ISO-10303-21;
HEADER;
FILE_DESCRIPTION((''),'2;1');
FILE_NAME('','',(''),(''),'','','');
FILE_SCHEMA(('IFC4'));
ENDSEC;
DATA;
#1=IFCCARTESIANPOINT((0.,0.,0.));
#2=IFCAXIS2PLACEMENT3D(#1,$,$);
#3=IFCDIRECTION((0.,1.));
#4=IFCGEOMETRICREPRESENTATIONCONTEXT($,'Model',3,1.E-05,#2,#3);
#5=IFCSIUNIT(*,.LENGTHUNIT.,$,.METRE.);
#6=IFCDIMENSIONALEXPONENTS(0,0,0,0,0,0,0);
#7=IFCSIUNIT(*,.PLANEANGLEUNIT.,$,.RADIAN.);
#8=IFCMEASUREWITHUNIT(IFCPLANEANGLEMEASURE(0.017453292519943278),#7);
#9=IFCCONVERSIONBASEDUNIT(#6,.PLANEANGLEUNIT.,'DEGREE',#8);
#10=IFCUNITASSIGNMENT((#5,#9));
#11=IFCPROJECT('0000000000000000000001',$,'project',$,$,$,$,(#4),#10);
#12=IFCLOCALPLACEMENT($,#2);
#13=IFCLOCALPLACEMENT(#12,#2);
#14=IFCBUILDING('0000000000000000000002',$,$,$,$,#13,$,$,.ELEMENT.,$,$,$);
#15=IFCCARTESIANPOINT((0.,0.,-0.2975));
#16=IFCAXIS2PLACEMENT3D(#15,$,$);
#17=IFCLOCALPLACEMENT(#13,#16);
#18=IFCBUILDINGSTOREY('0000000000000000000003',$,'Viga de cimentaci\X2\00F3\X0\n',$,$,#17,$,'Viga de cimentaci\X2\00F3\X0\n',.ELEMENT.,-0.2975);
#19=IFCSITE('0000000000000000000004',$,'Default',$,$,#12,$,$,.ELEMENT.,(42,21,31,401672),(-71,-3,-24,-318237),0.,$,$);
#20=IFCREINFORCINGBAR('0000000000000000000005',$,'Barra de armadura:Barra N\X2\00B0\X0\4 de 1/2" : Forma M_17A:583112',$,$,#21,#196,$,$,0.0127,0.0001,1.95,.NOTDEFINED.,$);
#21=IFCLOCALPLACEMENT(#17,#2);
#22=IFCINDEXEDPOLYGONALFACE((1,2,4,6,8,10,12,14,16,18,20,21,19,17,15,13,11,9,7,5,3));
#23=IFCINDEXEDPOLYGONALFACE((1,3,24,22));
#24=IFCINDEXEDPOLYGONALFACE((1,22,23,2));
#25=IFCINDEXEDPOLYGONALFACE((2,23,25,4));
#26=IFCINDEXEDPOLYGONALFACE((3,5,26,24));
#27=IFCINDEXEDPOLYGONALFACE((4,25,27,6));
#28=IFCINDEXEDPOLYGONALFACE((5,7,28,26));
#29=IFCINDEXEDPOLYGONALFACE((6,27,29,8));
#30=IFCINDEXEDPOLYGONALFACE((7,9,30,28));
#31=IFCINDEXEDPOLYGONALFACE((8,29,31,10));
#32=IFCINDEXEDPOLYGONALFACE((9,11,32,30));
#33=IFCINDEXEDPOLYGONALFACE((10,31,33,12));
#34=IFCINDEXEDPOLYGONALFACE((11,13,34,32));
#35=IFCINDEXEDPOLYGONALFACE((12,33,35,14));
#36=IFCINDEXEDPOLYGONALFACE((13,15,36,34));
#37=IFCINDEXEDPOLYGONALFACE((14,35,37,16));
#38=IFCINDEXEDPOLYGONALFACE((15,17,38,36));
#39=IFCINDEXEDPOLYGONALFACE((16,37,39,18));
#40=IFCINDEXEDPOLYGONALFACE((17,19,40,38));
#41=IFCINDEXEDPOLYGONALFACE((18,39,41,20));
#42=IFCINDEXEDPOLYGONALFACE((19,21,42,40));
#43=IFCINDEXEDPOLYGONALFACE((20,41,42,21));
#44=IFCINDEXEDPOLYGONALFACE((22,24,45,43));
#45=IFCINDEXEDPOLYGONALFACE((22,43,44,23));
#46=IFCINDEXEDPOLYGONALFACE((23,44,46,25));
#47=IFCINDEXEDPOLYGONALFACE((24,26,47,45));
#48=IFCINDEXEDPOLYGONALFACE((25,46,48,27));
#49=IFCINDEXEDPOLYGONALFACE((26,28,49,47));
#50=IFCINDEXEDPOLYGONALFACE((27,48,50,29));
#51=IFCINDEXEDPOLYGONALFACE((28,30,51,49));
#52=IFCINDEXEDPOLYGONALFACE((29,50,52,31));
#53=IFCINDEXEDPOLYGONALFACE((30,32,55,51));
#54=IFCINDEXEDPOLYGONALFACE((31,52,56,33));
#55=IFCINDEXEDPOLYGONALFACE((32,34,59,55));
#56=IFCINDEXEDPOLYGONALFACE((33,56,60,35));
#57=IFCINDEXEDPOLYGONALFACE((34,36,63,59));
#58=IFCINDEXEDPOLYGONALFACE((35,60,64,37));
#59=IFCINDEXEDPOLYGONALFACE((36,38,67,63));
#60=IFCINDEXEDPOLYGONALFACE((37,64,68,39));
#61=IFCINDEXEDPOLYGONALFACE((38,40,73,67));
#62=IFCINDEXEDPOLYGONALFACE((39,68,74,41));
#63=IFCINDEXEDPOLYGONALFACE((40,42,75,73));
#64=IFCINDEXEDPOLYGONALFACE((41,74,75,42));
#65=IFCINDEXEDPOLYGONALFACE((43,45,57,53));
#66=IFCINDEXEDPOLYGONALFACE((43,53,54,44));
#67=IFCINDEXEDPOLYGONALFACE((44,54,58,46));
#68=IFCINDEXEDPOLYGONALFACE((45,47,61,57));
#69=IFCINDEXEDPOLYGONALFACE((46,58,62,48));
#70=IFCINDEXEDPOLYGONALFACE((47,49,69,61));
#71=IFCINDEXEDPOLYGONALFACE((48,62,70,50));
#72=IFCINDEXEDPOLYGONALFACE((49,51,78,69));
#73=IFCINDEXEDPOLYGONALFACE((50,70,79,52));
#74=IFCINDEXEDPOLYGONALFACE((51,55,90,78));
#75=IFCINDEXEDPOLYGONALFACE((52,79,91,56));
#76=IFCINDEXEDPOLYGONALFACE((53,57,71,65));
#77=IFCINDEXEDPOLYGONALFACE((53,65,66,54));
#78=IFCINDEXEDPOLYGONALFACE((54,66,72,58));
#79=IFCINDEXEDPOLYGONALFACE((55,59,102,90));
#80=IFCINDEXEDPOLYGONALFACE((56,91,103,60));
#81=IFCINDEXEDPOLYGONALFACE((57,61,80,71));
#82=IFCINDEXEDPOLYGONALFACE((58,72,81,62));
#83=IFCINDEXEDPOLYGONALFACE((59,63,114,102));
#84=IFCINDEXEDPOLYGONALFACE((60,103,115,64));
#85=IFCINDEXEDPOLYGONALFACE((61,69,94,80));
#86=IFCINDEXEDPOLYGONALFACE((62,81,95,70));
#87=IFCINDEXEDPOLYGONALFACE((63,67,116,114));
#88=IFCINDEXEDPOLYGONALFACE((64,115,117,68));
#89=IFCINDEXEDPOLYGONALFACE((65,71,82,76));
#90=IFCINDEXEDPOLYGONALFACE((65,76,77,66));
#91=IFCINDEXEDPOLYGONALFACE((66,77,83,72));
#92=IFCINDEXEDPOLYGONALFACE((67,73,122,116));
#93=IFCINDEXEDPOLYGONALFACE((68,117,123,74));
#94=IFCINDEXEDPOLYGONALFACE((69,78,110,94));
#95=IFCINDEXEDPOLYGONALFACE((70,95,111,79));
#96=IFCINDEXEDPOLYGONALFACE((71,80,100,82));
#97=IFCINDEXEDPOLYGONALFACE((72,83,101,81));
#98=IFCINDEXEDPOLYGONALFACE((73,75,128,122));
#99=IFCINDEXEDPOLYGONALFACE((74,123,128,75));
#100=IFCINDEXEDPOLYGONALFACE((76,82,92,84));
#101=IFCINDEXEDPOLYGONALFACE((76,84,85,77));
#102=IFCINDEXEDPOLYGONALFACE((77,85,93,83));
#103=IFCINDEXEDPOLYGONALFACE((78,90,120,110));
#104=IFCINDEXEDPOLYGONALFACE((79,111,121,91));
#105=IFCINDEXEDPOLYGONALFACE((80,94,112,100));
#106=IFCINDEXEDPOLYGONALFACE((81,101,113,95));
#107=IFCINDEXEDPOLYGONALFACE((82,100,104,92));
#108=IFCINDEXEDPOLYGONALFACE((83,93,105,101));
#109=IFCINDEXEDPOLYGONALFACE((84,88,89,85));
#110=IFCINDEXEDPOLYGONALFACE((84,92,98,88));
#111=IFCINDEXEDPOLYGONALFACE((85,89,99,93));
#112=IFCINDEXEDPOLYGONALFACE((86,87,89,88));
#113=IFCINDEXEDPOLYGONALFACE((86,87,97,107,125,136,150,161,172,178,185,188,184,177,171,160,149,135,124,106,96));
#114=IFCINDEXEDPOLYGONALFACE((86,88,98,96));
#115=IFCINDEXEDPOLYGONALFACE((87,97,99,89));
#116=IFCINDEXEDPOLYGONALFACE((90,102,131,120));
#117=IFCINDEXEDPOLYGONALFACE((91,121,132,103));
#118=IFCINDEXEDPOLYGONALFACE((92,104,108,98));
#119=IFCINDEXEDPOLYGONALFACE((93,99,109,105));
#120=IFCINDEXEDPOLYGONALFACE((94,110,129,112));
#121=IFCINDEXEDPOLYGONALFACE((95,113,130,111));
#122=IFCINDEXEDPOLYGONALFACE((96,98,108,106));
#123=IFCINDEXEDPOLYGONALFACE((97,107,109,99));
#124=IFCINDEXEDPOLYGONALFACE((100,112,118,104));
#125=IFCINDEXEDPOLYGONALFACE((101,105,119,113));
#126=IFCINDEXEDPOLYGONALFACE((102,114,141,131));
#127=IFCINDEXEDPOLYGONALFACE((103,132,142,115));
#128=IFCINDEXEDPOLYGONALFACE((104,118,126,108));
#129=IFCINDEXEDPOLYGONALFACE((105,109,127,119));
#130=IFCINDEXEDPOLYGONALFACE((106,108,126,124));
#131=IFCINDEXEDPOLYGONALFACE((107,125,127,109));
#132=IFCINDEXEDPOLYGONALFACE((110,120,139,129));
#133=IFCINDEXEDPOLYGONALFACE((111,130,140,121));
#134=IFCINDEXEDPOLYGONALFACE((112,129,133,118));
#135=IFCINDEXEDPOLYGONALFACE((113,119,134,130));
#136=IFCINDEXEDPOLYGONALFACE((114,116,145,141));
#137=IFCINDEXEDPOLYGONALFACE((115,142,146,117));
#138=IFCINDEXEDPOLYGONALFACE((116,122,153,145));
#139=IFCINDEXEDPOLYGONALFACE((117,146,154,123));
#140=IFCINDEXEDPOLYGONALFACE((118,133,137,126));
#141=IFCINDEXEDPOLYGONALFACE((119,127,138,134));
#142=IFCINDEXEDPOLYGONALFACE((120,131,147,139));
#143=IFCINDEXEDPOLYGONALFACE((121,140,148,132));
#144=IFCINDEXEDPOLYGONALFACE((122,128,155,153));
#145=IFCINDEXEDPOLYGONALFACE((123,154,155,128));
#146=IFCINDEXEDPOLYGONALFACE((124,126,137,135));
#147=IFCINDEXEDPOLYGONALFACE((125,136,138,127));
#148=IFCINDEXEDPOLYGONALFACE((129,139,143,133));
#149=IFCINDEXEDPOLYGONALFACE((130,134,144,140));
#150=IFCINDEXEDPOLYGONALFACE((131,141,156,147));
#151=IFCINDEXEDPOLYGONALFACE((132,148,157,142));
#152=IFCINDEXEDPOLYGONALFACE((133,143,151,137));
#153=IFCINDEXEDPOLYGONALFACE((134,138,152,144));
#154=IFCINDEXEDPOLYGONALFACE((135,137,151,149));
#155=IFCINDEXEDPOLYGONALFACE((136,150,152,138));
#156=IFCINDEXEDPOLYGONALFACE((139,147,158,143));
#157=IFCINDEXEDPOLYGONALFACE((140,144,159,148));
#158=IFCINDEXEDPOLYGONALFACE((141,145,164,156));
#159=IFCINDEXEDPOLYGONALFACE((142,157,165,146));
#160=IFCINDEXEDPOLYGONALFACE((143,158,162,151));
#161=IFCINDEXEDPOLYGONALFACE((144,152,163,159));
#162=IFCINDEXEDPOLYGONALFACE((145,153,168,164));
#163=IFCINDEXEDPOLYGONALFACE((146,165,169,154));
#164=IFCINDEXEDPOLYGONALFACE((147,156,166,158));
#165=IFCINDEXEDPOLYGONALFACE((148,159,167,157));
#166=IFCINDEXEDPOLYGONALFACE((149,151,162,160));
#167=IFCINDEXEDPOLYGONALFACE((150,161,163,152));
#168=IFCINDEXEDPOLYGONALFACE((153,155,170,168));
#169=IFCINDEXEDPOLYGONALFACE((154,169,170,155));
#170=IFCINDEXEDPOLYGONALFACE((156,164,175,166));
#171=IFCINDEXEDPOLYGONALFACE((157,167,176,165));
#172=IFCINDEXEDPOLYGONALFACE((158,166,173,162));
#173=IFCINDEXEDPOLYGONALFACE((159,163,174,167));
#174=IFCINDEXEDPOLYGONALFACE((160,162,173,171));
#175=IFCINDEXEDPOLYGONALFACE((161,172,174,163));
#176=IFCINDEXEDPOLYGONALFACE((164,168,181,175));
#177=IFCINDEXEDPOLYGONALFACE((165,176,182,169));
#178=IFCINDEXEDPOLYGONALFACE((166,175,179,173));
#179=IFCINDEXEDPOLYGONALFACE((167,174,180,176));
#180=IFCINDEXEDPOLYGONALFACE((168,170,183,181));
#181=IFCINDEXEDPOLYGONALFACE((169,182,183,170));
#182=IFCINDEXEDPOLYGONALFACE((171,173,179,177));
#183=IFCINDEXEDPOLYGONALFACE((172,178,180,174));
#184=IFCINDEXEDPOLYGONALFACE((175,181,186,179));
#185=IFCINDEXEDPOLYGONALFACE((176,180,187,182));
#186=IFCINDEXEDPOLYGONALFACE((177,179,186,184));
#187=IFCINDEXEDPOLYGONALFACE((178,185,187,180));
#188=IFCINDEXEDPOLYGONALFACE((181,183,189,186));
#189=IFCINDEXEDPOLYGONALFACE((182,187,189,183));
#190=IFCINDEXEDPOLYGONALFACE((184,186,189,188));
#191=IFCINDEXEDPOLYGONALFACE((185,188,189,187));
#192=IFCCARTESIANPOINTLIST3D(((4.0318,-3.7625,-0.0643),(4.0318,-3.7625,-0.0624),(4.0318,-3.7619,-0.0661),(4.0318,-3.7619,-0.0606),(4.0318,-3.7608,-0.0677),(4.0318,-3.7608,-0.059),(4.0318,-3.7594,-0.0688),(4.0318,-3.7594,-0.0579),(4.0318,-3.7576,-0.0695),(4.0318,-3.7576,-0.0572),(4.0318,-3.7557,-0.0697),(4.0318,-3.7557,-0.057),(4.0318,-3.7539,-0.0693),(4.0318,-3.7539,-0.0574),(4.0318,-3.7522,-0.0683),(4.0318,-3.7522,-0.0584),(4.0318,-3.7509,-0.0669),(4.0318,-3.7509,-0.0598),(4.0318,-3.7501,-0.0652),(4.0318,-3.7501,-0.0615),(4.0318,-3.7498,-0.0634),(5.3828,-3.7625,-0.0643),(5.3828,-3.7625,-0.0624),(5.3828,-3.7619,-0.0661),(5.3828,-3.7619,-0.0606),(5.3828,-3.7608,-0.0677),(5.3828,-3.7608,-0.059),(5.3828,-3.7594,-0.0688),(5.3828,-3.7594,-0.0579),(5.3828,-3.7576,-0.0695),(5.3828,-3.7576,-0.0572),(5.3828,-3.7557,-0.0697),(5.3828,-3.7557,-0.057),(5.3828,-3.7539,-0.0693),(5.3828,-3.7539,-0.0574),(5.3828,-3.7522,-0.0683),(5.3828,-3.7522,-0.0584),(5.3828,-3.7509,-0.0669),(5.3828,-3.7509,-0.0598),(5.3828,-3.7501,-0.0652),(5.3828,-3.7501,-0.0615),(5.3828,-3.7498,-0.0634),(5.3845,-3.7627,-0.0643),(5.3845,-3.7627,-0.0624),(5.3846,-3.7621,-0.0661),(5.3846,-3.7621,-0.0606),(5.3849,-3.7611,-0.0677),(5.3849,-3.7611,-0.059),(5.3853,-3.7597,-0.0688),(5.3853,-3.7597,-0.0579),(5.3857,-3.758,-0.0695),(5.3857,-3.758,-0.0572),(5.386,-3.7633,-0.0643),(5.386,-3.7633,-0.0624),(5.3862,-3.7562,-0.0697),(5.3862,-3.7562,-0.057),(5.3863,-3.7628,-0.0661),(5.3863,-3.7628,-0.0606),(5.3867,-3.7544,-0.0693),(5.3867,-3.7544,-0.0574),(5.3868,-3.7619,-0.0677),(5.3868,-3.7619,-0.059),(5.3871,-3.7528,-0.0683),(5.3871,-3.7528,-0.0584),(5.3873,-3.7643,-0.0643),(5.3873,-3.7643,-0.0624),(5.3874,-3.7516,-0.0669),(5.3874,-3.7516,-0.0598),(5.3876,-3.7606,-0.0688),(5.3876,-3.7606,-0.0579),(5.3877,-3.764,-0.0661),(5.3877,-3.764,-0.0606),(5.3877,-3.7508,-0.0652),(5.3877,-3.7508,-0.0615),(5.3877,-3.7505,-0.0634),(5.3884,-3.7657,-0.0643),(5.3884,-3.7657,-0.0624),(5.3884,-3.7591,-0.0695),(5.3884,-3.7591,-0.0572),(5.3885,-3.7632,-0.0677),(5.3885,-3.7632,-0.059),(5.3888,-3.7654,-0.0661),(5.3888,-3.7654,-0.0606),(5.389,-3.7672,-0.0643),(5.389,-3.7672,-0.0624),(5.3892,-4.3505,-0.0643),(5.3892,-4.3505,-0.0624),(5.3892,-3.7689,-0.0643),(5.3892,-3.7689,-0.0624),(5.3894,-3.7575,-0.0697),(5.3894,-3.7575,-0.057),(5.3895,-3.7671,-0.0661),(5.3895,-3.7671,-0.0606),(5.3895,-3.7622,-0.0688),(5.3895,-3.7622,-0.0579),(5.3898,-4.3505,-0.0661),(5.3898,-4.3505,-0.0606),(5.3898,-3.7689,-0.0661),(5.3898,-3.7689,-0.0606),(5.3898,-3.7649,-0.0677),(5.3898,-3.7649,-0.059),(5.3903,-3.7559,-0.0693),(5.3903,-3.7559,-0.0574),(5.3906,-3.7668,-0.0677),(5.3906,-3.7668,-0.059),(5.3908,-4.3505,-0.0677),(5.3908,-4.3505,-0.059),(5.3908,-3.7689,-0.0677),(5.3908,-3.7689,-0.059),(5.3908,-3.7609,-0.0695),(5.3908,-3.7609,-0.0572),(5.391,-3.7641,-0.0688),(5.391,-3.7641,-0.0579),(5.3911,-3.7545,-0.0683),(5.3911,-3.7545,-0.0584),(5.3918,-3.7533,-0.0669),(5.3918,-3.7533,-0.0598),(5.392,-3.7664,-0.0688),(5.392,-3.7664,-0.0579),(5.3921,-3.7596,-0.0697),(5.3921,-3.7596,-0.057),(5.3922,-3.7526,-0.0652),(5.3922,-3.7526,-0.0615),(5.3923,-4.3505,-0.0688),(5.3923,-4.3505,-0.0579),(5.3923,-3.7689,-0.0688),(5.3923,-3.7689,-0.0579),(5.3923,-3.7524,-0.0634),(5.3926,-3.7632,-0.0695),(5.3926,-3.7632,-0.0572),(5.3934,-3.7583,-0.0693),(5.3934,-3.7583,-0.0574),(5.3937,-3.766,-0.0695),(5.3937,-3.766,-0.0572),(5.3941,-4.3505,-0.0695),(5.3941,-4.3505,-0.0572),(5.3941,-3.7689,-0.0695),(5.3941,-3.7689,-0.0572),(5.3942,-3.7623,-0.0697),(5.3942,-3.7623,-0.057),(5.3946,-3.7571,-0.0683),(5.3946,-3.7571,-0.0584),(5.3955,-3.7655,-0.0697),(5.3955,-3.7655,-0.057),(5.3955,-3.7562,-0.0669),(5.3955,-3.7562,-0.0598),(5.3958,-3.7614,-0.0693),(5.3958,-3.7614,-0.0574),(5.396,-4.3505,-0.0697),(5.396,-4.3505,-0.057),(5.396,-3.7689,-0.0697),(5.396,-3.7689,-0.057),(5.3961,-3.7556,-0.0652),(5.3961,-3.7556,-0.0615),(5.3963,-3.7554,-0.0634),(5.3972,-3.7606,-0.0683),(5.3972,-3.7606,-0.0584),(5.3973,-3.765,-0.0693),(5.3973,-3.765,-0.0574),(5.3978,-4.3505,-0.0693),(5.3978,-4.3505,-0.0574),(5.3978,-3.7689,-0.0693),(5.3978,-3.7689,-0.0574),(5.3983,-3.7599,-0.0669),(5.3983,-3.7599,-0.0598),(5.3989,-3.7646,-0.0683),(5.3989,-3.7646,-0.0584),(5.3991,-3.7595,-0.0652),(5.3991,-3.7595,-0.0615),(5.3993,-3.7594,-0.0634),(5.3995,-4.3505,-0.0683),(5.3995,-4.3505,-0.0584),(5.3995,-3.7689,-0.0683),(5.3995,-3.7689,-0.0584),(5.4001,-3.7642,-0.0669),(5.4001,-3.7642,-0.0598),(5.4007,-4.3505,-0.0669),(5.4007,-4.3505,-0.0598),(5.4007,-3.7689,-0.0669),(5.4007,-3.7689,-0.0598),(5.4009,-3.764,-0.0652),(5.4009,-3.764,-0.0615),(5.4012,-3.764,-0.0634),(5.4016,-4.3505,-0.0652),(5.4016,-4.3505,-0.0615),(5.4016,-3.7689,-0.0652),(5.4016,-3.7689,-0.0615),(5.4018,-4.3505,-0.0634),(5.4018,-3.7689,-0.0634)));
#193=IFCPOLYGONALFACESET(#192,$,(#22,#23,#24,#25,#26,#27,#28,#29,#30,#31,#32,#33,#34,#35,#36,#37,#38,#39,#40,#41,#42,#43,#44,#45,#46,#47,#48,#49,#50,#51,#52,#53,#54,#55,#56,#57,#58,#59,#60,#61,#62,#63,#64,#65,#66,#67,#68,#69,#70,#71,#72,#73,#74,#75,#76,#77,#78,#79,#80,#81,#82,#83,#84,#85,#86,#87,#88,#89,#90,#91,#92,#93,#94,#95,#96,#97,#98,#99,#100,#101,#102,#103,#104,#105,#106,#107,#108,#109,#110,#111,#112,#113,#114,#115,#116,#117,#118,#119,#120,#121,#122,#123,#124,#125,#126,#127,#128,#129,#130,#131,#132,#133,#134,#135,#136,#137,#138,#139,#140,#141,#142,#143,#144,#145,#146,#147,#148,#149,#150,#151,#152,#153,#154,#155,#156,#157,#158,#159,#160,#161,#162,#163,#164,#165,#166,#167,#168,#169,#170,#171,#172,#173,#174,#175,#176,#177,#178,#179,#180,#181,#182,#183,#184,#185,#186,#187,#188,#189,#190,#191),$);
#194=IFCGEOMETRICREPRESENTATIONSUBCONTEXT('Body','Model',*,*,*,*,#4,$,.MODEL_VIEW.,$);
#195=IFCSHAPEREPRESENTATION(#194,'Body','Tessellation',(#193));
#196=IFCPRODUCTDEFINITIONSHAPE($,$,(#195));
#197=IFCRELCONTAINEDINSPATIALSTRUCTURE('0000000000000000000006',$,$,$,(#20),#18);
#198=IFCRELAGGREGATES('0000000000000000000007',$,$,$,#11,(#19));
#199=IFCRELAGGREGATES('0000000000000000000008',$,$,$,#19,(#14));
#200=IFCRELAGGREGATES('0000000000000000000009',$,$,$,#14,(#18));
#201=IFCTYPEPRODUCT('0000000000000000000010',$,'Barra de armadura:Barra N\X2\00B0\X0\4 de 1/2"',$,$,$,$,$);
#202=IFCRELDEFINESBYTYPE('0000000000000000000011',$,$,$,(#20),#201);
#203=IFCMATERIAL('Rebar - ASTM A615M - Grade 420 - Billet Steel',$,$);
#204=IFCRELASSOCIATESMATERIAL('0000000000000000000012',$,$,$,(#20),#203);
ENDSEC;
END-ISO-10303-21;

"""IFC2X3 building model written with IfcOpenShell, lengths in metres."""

from ifc_helpers import new_model, entity, si_unit, converted_unit, direction, frame, origin, place, context, subcontext, project, spatial, material, type_object, element, save


model = new_model("IFC2X3")

# Units and contexts
model_context = context("Model", 3, precision=1e-05, world=origin(), true_north=direction((0.0, 1.0)))
body_context = subcontext(model_context, "Body", "Model", "MODEL_VIEW")
ifc_project = project(units=[si_unit("LENGTHUNIT", "METRE"), converted_unit("PLANEANGLEUNIT", "DEGREE", entity("IfcPlaneAngleMeasure", 0.017453292519943278), si_unit("PLANEANGLEUNIT", "RADIAN"), dimensions=[0, 0, 0, 0, 0, 0, 0])], contexts=[model_context])

# Site, building, storey
site_placement = place(None, origin())
site = spatial("IfcSite", under=ifc_project, at=site_placement, Name="Default", CompositionType="ELEMENT", RefLatitude=(42, 21, 31, 401672), RefLongitude=(-71, -3, -24, -318237), RefElevation=0.0)
building_placement = place(site_placement, origin())
building = spatial("IfcBuilding", under=site, at=building_placement, CompositionType="ELEMENT")
storey_placement = place(building_placement, frame((0.0, 0.0, -0.2975)))
storey = spatial("IfcBuildingStorey", under=building, at=storey_placement, Name="Viga de cimentación", LongName="Viga de cimentación", CompositionType="ELEMENT", Elevation=-0.2975)

# Reinforcing bar
ifc_material = material(Name="Rebar - ASTM A615M - Grade 420 - Billet Steel")
type_product_1 = type_object("IfcTypeProduct", Name="Barra de armadura:Barra N°4 de 1/2\"")
reinforcing_bar_1_placement = place(storey_placement, origin())
element("IfcReinforcingBar", 1, at=reinforcing_bar_1_placement, inside=storey, type_object=type_product_1, material=ifc_material, Name="Barra de armadura:Barra N°4 de 1/2\" : Forma M_17A:583112", BarLength=1.95, BarRole="NOTDEFINED", CrossSectionArea=0.0001, NominalDiameter=0.0127, context=body_context, shape_type="AdvancedSweptSolid", body=[
    entity("IfcSweptDiskSolid", entity("IfcCompositeCurve", [entity("IfcCompositeCurveSegment", "CONTINUOUS", True, entity("IfcPolyline", [entity("IfcCartesianPoint", [5.3955, -4.3505, -0.0634]), entity("IfcCartesianPoint", [5.3955, -3.7689, -0.0634])])), entity("IfcCompositeCurveSegment", "CONTINUOUS", True, entity("IfcTrimmedCurve", entity("IfcCircle", entity("IfcAxis2Placement3D", entity("IfcCartesianPoint", [5.3828, -3.7689, -0.0634]), entity("IfcDirection", [0.0, 0.0, 1.0]), entity("IfcDirection", [0.0, 1.0, 0.0])), 0.0127), [entity("IfcParameterValue", 270.0)], [entity("IfcParameterValue", 360.0)], True, "PARAMETER")), entity("IfcCompositeCurveSegment", "CONTINUOUS", True, entity("IfcPolyline", [entity("IfcCartesianPoint", [5.3828, -3.7562, -0.0634]), entity("IfcCartesianPoint", [4.0318, -3.7562, -0.0634])]))], False), 0.0063, None, 0.0, 92.0),
])

save(model, "model.ifc")
